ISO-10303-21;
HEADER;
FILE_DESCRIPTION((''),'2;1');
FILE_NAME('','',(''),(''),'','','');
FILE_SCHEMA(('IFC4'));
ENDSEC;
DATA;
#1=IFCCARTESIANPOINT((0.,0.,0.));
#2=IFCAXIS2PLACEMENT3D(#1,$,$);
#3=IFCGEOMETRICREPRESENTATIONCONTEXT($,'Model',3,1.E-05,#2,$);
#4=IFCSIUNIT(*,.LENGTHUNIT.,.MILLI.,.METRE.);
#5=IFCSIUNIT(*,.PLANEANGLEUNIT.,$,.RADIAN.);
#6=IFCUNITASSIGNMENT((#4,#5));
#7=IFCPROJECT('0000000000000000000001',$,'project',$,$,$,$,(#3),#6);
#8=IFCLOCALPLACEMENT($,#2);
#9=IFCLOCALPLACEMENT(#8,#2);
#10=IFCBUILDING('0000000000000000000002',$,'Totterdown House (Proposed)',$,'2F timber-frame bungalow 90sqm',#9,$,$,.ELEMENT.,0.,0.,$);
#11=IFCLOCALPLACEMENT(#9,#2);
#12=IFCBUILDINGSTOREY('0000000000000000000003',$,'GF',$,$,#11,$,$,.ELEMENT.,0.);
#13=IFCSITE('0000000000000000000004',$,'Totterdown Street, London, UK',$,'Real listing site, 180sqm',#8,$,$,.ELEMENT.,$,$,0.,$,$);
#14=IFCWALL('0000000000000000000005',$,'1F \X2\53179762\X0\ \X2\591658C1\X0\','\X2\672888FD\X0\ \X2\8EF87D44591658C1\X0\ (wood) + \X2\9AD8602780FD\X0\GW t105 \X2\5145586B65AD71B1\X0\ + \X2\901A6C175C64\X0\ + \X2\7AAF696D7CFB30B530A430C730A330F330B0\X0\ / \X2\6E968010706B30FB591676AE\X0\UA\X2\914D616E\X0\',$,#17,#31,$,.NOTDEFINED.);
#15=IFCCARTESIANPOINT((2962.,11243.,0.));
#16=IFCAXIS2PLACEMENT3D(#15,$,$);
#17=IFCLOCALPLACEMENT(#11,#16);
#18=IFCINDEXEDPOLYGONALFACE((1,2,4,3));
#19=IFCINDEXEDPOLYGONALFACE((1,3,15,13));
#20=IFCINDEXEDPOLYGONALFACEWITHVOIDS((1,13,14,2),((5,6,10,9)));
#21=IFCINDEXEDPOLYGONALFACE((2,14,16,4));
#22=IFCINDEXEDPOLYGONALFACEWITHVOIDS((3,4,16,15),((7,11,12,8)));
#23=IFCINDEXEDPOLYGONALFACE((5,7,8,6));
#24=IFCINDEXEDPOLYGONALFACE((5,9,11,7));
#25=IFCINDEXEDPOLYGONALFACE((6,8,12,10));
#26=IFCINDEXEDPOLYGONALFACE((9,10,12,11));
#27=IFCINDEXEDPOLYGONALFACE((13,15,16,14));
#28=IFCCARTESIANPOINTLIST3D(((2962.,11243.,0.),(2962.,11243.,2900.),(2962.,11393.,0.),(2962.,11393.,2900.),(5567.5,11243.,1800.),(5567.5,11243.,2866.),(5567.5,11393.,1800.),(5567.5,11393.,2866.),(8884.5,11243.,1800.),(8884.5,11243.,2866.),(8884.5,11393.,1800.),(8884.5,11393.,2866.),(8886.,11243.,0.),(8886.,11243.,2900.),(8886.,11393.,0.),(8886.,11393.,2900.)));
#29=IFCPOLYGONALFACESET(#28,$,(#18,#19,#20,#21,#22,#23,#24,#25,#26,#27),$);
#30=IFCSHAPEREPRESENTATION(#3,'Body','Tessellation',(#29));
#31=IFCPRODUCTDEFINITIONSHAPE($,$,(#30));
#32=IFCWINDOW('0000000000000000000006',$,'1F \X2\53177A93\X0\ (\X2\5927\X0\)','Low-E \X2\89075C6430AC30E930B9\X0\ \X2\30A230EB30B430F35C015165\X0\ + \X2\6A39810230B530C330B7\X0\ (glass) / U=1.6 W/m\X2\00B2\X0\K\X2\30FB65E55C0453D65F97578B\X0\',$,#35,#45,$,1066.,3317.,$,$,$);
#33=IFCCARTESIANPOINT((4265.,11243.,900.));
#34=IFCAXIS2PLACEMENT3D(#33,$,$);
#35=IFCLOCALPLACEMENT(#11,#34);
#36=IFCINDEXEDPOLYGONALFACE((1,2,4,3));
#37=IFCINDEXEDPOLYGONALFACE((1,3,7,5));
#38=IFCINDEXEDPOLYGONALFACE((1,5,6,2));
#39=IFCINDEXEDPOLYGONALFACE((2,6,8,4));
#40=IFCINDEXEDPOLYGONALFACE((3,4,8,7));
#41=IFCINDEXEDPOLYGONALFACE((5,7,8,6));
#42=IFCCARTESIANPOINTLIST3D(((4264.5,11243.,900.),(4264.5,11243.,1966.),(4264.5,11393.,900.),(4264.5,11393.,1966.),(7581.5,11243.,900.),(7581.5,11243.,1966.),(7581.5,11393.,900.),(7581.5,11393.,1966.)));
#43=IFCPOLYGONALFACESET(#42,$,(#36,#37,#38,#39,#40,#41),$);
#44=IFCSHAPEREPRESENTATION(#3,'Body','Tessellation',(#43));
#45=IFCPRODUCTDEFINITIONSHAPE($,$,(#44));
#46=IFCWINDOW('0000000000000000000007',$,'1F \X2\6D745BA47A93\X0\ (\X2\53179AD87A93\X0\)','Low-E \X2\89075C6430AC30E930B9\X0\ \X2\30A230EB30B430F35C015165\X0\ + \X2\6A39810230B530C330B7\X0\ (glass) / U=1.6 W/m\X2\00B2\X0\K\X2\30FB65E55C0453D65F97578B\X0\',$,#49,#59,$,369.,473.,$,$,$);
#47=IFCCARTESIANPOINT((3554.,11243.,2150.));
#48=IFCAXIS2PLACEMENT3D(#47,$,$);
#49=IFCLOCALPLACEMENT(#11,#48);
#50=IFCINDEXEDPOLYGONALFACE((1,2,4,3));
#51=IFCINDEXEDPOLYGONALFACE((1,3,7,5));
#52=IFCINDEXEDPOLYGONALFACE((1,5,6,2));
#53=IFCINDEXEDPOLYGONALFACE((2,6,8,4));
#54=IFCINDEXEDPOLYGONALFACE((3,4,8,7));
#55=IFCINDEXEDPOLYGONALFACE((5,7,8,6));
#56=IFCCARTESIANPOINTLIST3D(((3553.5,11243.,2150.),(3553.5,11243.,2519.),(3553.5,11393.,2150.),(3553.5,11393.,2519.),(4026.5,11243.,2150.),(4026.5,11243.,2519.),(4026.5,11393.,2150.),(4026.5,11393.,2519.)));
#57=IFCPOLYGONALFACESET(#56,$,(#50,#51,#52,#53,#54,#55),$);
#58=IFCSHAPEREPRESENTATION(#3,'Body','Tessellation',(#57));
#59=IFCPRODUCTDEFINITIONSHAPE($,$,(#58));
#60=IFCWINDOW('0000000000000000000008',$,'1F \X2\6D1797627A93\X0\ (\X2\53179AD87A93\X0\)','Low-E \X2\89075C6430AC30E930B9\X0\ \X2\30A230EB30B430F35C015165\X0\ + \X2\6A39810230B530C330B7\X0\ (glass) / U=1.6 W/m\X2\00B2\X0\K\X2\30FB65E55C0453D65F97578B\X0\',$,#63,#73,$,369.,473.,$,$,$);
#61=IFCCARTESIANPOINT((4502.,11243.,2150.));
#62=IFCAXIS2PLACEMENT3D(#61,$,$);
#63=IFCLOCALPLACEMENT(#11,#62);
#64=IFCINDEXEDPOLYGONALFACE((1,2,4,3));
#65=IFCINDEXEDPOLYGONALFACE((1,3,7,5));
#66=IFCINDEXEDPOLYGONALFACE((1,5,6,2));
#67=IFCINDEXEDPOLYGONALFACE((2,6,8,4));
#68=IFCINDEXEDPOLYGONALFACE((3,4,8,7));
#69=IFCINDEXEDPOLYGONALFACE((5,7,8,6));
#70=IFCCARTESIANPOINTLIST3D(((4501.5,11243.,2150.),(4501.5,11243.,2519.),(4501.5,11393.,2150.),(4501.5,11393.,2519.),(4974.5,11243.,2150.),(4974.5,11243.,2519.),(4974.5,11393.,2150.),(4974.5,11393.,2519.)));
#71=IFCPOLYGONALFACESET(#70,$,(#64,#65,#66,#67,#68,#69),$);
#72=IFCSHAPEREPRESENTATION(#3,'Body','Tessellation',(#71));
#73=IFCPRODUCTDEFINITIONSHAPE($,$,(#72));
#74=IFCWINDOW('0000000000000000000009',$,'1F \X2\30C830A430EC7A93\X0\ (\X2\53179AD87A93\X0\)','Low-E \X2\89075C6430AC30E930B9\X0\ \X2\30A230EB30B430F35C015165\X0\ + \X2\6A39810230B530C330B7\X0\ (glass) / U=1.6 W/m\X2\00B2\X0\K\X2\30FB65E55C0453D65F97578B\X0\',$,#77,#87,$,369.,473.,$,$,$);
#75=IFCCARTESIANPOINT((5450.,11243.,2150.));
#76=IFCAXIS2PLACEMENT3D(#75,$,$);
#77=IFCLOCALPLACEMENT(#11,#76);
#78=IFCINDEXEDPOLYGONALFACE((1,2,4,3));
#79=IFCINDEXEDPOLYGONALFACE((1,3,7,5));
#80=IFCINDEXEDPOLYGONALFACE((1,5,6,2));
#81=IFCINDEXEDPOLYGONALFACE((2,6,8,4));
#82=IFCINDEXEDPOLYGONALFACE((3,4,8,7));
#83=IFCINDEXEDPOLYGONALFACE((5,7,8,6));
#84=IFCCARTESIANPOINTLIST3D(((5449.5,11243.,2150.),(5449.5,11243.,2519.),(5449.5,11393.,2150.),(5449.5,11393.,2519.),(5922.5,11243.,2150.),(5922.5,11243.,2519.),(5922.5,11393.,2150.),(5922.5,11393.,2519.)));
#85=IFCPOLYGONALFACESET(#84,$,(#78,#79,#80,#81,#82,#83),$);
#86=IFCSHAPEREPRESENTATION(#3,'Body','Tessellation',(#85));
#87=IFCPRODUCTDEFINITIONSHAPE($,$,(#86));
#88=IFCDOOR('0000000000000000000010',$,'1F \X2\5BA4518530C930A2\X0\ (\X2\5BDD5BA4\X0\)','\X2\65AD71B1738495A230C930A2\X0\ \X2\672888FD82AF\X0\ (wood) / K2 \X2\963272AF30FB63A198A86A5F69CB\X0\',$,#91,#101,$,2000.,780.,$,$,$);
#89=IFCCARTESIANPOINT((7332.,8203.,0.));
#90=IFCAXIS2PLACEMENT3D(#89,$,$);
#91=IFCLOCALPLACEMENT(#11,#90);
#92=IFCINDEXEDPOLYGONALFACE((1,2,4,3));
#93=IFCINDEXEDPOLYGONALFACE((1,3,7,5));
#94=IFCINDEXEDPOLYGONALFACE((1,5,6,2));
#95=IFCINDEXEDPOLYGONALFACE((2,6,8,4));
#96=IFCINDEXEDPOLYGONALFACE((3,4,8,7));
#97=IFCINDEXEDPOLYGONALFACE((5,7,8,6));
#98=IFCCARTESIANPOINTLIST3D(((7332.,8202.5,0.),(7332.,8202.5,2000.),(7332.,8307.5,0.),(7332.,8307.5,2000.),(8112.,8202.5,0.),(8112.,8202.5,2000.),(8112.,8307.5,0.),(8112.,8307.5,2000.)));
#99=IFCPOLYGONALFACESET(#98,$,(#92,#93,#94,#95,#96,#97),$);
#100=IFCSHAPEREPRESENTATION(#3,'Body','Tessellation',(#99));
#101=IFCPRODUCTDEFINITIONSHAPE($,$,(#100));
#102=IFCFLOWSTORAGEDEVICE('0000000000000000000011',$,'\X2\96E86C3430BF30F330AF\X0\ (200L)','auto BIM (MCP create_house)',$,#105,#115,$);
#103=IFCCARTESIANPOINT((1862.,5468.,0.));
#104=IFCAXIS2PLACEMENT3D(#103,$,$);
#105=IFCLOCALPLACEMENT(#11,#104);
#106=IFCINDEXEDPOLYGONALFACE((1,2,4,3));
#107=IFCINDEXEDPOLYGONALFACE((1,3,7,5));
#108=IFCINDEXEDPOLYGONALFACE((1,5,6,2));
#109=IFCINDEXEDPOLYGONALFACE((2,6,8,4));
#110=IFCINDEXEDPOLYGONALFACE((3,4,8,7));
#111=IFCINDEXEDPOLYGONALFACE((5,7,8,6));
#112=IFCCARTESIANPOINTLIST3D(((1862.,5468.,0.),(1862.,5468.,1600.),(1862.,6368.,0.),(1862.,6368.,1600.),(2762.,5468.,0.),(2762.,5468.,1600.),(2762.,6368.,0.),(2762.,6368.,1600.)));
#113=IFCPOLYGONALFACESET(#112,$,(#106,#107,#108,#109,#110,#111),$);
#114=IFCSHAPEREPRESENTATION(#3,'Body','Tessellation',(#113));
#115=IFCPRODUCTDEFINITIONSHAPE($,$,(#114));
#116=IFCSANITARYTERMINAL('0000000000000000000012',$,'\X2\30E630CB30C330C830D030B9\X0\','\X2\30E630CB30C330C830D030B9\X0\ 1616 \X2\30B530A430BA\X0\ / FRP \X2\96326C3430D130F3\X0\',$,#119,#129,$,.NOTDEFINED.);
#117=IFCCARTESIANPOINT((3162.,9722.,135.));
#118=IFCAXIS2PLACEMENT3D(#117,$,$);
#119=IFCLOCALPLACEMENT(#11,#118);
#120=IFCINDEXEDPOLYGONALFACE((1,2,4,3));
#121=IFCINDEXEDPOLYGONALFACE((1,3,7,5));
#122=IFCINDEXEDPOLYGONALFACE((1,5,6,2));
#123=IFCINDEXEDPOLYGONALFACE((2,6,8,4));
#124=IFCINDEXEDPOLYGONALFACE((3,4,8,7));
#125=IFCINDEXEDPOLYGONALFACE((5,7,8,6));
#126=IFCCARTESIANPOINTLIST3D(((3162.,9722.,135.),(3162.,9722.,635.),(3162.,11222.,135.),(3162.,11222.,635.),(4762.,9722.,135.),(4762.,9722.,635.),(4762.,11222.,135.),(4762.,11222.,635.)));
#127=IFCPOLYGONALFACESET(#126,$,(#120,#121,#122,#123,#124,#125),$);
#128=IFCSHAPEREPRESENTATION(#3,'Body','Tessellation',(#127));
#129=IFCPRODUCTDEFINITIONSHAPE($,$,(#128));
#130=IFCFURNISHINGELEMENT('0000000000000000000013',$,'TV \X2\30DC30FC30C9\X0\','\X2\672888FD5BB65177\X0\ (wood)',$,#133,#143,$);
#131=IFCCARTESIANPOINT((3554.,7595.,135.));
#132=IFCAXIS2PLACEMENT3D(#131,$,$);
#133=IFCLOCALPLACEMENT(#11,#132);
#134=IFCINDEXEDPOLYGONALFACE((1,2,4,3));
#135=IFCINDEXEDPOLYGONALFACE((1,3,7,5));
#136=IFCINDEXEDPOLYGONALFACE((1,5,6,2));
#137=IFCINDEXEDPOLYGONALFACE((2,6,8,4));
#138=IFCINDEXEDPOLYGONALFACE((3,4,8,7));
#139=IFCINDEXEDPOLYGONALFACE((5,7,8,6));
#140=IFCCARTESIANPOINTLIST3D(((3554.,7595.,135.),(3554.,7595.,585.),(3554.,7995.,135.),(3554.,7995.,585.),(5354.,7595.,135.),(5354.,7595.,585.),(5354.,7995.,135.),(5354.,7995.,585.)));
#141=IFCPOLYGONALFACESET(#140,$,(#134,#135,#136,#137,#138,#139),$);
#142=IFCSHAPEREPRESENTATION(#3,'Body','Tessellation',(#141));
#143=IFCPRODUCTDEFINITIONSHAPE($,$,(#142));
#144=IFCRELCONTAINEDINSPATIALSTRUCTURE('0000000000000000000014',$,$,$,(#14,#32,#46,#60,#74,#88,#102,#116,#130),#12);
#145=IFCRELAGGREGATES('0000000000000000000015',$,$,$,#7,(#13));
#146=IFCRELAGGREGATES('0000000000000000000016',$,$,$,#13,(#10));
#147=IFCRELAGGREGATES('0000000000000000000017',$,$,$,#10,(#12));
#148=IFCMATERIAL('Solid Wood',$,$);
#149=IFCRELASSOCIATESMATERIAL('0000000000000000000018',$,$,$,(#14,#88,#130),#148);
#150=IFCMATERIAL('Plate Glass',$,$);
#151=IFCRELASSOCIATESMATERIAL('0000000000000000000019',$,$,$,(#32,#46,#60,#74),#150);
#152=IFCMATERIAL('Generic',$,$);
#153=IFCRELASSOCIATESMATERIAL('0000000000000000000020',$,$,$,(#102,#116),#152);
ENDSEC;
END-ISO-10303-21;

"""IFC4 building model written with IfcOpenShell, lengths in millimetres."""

from ifc_helpers import new_model, si_unit, frame, frame_2d, origin, place, context, project, spatial, rectangle, extrude, material, element, fill, save


model = new_model("IFC4")

# Units and contexts
model_context = context("Model", 3, precision=1e-05, world=origin())
ifc_project = project(units=[si_unit("LENGTHUNIT", "METRE", prefix="MILLI"), si_unit("PLANEANGLEUNIT", "RADIAN")], contexts=[model_context])

# Site, building, storey
site_placement = place(None, origin())
site = spatial("IfcSite", under=ifc_project, at=site_placement, Name="Totterdown Street, London, UK", ObjectType="Real listing site, 180sqm", CompositionType="ELEMENT", RefElevation=0.0)
building_placement = place(site_placement, origin())
building = spatial("IfcBuilding", under=site, at=building_placement, Name="Totterdown House (Proposed)", ObjectType="2F timber-frame bungalow 90sqm", CompositionType="ELEMENT", ElevationOfRefHeight=0.0, ElevationOfTerrain=0.0)
storey_placement = place(building_placement, origin())
storey = spatial("IfcBuildingStorey", under=building, at=storey_placement, Name="GF", CompositionType="ELEMENT", Elevation=0.0)

# Wall, openings, windows
ifc_material_1 = material(Name="Solid Wood")
wall_1_placement = place(storey_placement, frame((2962.0, 11243.0, 0.0)))
wall_1 = element("IfcWall", 1, at=wall_1_placement, inside=storey, material=ifc_material_1, Name="1F 北面 外壁", Description="木製 軸組外壁 (wood) + 高性能GW t105 充填断熱 + 通気層 + 窯業系サイディング / 準耐火・外皮UA配慮", PredefinedType="NOTDEFINED", context=model_context, shape_type="SweptSolid", body=[
    extrude(rectangle(XDim=5924.0, YDim=150.0, at=frame_2d((2962.0, 75.0))), frame((2962.0, 11243.0, 0.0)), (0.0, 0.0, 1.0), 2900.0),
])
opening_1_placement = place(storey_placement, frame((4265.0, 11243.0, 900.0)))
opening_1 = element("IfcOpeningElement", 2, at=opening_1_placement, cuts=wall_1, PredefinedType="NOTDEFINED", context=model_context, shape_type="SweptSolid", body=[
    extrude(rectangle(XDim=3317.0, YDim=150.0, at=frame_2d((1658.0, 75.0))), frame((4265.0, 11243.0, 900.0)), (0.0, 0.0, 1.0), 1066.0),
])
opening_2_placement = place(storey_placement, frame((3554.0, 11243.0, 2150.0)))
opening_2 = element("IfcOpeningElement", 3, at=opening_2_placement, cuts=wall_1, PredefinedType="NOTDEFINED", context=model_context, shape_type="SweptSolid", body=[
    extrude(rectangle(XDim=473.0, YDim=150.0, at=frame_2d((236.0, 75.0))), frame((3554.0, 11243.0, 2150.0)), (0.0, 0.0, 1.0), 369.0),
])
opening_3_placement = place(storey_placement, frame((4502.0, 11243.0, 2150.0)))
opening_3 = element("IfcOpeningElement", 4, at=opening_3_placement, cuts=wall_1, PredefinedType="NOTDEFINED", context=model_context, shape_type="SweptSolid", body=[
    extrude(rectangle(XDim=473.0, YDim=150.0, at=frame_2d((236.0, 75.0))), frame((4502.0, 11243.0, 2150.0)), (0.0, 0.0, 1.0), 369.0),
])
opening_4_placement = place(storey_placement, frame((5450.0, 11243.0, 2150.0)))
opening_4 = element("IfcOpeningElement", 5, at=opening_4_placement, cuts=wall_1, PredefinedType="NOTDEFINED", context=model_context, shape_type="SweptSolid", body=[
    extrude(rectangle(XDim=473.0, YDim=150.0, at=frame_2d((236.0, 75.0))), frame((5450.0, 11243.0, 2150.0)), (0.0, 0.0, 1.0), 369.0),
])
ifc_material_2 = material(Name="Plate Glass")
window_1_placement = place(storey_placement, frame((4265.0, 11243.0, 900.0)))
window_1 = element("IfcWindow", 6, at=window_1_placement, inside=storey, material=ifc_material_2, Name="1F 北窓 (大)", Description="Low-E 複層ガラス アルゴン封入 + 樹脂サッシ (glass) / U=1.6 W/m²K・日射取得型", OverallHeight=1066.0, OverallWidth=3317.0, context=model_context, shape_type="SweptSolid", body=[
    extrude(rectangle(XDim=3317.0, YDim=150.0, at=frame_2d((1658.0, 75.0))), frame((4265.0, 11243.0, 900.0)), (0.0, 0.0, 1.0), 1066.0),
])
fill(opening_1, window_1)
window_2_placement = place(storey_placement, frame((3554.0, 11243.0, 2150.0)))
window_2 = element("IfcWindow", 7, at=window_2_placement, inside=storey, material=ifc_material_2, Name="1F 浴室窓 (北高窓)", Description="Low-E 複層ガラス アルゴン封入 + 樹脂サッシ (glass) / U=1.6 W/m²K・日射取得型", OverallHeight=369.0, OverallWidth=473.0, context=model_context, shape_type="SweptSolid", body=[
    extrude(rectangle(XDim=473.0, YDim=150.0, at=frame_2d((236.0, 75.0))), frame((3554.0, 11243.0, 2150.0)), (0.0, 0.0, 1.0), 369.0),
])
fill(opening_2, window_2)
window_3_placement = place(storey_placement, frame((4502.0, 11243.0, 2150.0)))
window_3 = element("IfcWindow", 8, at=window_3_placement, inside=storey, material=ifc_material_2, Name="1F 洗面窓 (北高窓)", Description="Low-E 複層ガラス アルゴン封入 + 樹脂サッシ (glass) / U=1.6 W/m²K・日射取得型", OverallHeight=369.0, OverallWidth=473.0, context=model_context, shape_type="SweptSolid", body=[
    extrude(rectangle(XDim=473.0, YDim=150.0, at=frame_2d((236.0, 75.0))), frame((4502.0, 11243.0, 2150.0)), (0.0, 0.0, 1.0), 369.0),
])
fill(opening_3, window_3)
window_4_placement = place(storey_placement, frame((5450.0, 11243.0, 2150.0)))
window_4 = element("IfcWindow", 9, at=window_4_placement, inside=storey, material=ifc_material_2, Name="1F トイレ窓 (北高窓)", Description="Low-E 複層ガラス アルゴン封入 + 樹脂サッシ (glass) / U=1.6 W/m²K・日射取得型", OverallHeight=369.0, OverallWidth=473.0, context=model_context, shape_type="SweptSolid", body=[
    extrude(rectangle(XDim=473.0, YDim=150.0, at=frame_2d((236.0, 75.0))), frame((5450.0, 11243.0, 2150.0)), (0.0, 0.0, 1.0), 369.0),
])
fill(opening_4, window_4)

# Door
door_1_placement = place(storey_placement, frame((7332.0, 8203.0, 0.0)))
element("IfcDoor", 10, at=door_1_placement, inside=storey, material=ifc_material_1, Name="1F 室内ドア (寝室)", Description="断熱玄関ドア 木製芯 (wood) / K2 防犯・採風機構", OverallHeight=2000.0, OverallWidth=780.0, context=model_context, shape_type="SweptSolid", body=[
    extrude(rectangle(XDim=780.0, YDim=105.0, at=frame_2d((390.0, 52.0))), frame((7332.0, 8203.0, 0.0)), (0.0, 0.0, 1.0), 2000.0),
])

# Flow storage device
ifc_material_3 = material(Name="Generic")
flow_storage_device_placement = place(storey_placement, frame((1862.0, 5468.0, 0.0)))
element("IfcFlowStorageDevice", 11, at=flow_storage_device_placement, inside=storey, material=ifc_material_3, Name="雨水タンク (200L)", Description="auto BIM (MCP create_house)", context=model_context, shape_type="SweptSolid", body=[
    extrude(rectangle(XDim=900.0, YDim=900.0, at=frame_2d((450.0, 450.0))), frame((1862.0, 5468.0, 0.0)), (0.0, 0.0, 1.0), 1600.0),
])

# Sanitary terminal
sanitary_terminal_placement = place(storey_placement, frame((3162.0, 9722.0, 135.0)))
element("IfcSanitaryTerminal", 12, at=sanitary_terminal_placement, inside=storey, material=ifc_material_3, Name="ユニットバス", Description="ユニットバス 1616 サイズ / FRP 防水パン", PredefinedType="NOTDEFINED", context=model_context, shape_type="SweptSolid", body=[
    extrude(rectangle(XDim=1600.0, YDim=1500.0, at=frame_2d((800.0, 750.0))), frame((3162.0, 9722.0, 135.0)), (0.0, 0.0, 1.0), 500.0),
])

# Furnishing element
furnishing_placement = place(storey_placement, frame((3554.0, 7595.0, 135.0)))
element("IfcFurnishingElement", 13, at=furnishing_placement, inside=storey, material=ifc_material_1, Name="TV ボード", Description="木製家具 (wood)", context=model_context, shape_type="SweptSolid", body=[
    extrude(rectangle(XDim=1800.0, YDim=400.0, at=frame_2d((900.0, 200.0))), frame((3554.0, 7595.0, 135.0)), (0.0, 0.0, 1.0), 450.0),
])

save(model, "model.ifc")
